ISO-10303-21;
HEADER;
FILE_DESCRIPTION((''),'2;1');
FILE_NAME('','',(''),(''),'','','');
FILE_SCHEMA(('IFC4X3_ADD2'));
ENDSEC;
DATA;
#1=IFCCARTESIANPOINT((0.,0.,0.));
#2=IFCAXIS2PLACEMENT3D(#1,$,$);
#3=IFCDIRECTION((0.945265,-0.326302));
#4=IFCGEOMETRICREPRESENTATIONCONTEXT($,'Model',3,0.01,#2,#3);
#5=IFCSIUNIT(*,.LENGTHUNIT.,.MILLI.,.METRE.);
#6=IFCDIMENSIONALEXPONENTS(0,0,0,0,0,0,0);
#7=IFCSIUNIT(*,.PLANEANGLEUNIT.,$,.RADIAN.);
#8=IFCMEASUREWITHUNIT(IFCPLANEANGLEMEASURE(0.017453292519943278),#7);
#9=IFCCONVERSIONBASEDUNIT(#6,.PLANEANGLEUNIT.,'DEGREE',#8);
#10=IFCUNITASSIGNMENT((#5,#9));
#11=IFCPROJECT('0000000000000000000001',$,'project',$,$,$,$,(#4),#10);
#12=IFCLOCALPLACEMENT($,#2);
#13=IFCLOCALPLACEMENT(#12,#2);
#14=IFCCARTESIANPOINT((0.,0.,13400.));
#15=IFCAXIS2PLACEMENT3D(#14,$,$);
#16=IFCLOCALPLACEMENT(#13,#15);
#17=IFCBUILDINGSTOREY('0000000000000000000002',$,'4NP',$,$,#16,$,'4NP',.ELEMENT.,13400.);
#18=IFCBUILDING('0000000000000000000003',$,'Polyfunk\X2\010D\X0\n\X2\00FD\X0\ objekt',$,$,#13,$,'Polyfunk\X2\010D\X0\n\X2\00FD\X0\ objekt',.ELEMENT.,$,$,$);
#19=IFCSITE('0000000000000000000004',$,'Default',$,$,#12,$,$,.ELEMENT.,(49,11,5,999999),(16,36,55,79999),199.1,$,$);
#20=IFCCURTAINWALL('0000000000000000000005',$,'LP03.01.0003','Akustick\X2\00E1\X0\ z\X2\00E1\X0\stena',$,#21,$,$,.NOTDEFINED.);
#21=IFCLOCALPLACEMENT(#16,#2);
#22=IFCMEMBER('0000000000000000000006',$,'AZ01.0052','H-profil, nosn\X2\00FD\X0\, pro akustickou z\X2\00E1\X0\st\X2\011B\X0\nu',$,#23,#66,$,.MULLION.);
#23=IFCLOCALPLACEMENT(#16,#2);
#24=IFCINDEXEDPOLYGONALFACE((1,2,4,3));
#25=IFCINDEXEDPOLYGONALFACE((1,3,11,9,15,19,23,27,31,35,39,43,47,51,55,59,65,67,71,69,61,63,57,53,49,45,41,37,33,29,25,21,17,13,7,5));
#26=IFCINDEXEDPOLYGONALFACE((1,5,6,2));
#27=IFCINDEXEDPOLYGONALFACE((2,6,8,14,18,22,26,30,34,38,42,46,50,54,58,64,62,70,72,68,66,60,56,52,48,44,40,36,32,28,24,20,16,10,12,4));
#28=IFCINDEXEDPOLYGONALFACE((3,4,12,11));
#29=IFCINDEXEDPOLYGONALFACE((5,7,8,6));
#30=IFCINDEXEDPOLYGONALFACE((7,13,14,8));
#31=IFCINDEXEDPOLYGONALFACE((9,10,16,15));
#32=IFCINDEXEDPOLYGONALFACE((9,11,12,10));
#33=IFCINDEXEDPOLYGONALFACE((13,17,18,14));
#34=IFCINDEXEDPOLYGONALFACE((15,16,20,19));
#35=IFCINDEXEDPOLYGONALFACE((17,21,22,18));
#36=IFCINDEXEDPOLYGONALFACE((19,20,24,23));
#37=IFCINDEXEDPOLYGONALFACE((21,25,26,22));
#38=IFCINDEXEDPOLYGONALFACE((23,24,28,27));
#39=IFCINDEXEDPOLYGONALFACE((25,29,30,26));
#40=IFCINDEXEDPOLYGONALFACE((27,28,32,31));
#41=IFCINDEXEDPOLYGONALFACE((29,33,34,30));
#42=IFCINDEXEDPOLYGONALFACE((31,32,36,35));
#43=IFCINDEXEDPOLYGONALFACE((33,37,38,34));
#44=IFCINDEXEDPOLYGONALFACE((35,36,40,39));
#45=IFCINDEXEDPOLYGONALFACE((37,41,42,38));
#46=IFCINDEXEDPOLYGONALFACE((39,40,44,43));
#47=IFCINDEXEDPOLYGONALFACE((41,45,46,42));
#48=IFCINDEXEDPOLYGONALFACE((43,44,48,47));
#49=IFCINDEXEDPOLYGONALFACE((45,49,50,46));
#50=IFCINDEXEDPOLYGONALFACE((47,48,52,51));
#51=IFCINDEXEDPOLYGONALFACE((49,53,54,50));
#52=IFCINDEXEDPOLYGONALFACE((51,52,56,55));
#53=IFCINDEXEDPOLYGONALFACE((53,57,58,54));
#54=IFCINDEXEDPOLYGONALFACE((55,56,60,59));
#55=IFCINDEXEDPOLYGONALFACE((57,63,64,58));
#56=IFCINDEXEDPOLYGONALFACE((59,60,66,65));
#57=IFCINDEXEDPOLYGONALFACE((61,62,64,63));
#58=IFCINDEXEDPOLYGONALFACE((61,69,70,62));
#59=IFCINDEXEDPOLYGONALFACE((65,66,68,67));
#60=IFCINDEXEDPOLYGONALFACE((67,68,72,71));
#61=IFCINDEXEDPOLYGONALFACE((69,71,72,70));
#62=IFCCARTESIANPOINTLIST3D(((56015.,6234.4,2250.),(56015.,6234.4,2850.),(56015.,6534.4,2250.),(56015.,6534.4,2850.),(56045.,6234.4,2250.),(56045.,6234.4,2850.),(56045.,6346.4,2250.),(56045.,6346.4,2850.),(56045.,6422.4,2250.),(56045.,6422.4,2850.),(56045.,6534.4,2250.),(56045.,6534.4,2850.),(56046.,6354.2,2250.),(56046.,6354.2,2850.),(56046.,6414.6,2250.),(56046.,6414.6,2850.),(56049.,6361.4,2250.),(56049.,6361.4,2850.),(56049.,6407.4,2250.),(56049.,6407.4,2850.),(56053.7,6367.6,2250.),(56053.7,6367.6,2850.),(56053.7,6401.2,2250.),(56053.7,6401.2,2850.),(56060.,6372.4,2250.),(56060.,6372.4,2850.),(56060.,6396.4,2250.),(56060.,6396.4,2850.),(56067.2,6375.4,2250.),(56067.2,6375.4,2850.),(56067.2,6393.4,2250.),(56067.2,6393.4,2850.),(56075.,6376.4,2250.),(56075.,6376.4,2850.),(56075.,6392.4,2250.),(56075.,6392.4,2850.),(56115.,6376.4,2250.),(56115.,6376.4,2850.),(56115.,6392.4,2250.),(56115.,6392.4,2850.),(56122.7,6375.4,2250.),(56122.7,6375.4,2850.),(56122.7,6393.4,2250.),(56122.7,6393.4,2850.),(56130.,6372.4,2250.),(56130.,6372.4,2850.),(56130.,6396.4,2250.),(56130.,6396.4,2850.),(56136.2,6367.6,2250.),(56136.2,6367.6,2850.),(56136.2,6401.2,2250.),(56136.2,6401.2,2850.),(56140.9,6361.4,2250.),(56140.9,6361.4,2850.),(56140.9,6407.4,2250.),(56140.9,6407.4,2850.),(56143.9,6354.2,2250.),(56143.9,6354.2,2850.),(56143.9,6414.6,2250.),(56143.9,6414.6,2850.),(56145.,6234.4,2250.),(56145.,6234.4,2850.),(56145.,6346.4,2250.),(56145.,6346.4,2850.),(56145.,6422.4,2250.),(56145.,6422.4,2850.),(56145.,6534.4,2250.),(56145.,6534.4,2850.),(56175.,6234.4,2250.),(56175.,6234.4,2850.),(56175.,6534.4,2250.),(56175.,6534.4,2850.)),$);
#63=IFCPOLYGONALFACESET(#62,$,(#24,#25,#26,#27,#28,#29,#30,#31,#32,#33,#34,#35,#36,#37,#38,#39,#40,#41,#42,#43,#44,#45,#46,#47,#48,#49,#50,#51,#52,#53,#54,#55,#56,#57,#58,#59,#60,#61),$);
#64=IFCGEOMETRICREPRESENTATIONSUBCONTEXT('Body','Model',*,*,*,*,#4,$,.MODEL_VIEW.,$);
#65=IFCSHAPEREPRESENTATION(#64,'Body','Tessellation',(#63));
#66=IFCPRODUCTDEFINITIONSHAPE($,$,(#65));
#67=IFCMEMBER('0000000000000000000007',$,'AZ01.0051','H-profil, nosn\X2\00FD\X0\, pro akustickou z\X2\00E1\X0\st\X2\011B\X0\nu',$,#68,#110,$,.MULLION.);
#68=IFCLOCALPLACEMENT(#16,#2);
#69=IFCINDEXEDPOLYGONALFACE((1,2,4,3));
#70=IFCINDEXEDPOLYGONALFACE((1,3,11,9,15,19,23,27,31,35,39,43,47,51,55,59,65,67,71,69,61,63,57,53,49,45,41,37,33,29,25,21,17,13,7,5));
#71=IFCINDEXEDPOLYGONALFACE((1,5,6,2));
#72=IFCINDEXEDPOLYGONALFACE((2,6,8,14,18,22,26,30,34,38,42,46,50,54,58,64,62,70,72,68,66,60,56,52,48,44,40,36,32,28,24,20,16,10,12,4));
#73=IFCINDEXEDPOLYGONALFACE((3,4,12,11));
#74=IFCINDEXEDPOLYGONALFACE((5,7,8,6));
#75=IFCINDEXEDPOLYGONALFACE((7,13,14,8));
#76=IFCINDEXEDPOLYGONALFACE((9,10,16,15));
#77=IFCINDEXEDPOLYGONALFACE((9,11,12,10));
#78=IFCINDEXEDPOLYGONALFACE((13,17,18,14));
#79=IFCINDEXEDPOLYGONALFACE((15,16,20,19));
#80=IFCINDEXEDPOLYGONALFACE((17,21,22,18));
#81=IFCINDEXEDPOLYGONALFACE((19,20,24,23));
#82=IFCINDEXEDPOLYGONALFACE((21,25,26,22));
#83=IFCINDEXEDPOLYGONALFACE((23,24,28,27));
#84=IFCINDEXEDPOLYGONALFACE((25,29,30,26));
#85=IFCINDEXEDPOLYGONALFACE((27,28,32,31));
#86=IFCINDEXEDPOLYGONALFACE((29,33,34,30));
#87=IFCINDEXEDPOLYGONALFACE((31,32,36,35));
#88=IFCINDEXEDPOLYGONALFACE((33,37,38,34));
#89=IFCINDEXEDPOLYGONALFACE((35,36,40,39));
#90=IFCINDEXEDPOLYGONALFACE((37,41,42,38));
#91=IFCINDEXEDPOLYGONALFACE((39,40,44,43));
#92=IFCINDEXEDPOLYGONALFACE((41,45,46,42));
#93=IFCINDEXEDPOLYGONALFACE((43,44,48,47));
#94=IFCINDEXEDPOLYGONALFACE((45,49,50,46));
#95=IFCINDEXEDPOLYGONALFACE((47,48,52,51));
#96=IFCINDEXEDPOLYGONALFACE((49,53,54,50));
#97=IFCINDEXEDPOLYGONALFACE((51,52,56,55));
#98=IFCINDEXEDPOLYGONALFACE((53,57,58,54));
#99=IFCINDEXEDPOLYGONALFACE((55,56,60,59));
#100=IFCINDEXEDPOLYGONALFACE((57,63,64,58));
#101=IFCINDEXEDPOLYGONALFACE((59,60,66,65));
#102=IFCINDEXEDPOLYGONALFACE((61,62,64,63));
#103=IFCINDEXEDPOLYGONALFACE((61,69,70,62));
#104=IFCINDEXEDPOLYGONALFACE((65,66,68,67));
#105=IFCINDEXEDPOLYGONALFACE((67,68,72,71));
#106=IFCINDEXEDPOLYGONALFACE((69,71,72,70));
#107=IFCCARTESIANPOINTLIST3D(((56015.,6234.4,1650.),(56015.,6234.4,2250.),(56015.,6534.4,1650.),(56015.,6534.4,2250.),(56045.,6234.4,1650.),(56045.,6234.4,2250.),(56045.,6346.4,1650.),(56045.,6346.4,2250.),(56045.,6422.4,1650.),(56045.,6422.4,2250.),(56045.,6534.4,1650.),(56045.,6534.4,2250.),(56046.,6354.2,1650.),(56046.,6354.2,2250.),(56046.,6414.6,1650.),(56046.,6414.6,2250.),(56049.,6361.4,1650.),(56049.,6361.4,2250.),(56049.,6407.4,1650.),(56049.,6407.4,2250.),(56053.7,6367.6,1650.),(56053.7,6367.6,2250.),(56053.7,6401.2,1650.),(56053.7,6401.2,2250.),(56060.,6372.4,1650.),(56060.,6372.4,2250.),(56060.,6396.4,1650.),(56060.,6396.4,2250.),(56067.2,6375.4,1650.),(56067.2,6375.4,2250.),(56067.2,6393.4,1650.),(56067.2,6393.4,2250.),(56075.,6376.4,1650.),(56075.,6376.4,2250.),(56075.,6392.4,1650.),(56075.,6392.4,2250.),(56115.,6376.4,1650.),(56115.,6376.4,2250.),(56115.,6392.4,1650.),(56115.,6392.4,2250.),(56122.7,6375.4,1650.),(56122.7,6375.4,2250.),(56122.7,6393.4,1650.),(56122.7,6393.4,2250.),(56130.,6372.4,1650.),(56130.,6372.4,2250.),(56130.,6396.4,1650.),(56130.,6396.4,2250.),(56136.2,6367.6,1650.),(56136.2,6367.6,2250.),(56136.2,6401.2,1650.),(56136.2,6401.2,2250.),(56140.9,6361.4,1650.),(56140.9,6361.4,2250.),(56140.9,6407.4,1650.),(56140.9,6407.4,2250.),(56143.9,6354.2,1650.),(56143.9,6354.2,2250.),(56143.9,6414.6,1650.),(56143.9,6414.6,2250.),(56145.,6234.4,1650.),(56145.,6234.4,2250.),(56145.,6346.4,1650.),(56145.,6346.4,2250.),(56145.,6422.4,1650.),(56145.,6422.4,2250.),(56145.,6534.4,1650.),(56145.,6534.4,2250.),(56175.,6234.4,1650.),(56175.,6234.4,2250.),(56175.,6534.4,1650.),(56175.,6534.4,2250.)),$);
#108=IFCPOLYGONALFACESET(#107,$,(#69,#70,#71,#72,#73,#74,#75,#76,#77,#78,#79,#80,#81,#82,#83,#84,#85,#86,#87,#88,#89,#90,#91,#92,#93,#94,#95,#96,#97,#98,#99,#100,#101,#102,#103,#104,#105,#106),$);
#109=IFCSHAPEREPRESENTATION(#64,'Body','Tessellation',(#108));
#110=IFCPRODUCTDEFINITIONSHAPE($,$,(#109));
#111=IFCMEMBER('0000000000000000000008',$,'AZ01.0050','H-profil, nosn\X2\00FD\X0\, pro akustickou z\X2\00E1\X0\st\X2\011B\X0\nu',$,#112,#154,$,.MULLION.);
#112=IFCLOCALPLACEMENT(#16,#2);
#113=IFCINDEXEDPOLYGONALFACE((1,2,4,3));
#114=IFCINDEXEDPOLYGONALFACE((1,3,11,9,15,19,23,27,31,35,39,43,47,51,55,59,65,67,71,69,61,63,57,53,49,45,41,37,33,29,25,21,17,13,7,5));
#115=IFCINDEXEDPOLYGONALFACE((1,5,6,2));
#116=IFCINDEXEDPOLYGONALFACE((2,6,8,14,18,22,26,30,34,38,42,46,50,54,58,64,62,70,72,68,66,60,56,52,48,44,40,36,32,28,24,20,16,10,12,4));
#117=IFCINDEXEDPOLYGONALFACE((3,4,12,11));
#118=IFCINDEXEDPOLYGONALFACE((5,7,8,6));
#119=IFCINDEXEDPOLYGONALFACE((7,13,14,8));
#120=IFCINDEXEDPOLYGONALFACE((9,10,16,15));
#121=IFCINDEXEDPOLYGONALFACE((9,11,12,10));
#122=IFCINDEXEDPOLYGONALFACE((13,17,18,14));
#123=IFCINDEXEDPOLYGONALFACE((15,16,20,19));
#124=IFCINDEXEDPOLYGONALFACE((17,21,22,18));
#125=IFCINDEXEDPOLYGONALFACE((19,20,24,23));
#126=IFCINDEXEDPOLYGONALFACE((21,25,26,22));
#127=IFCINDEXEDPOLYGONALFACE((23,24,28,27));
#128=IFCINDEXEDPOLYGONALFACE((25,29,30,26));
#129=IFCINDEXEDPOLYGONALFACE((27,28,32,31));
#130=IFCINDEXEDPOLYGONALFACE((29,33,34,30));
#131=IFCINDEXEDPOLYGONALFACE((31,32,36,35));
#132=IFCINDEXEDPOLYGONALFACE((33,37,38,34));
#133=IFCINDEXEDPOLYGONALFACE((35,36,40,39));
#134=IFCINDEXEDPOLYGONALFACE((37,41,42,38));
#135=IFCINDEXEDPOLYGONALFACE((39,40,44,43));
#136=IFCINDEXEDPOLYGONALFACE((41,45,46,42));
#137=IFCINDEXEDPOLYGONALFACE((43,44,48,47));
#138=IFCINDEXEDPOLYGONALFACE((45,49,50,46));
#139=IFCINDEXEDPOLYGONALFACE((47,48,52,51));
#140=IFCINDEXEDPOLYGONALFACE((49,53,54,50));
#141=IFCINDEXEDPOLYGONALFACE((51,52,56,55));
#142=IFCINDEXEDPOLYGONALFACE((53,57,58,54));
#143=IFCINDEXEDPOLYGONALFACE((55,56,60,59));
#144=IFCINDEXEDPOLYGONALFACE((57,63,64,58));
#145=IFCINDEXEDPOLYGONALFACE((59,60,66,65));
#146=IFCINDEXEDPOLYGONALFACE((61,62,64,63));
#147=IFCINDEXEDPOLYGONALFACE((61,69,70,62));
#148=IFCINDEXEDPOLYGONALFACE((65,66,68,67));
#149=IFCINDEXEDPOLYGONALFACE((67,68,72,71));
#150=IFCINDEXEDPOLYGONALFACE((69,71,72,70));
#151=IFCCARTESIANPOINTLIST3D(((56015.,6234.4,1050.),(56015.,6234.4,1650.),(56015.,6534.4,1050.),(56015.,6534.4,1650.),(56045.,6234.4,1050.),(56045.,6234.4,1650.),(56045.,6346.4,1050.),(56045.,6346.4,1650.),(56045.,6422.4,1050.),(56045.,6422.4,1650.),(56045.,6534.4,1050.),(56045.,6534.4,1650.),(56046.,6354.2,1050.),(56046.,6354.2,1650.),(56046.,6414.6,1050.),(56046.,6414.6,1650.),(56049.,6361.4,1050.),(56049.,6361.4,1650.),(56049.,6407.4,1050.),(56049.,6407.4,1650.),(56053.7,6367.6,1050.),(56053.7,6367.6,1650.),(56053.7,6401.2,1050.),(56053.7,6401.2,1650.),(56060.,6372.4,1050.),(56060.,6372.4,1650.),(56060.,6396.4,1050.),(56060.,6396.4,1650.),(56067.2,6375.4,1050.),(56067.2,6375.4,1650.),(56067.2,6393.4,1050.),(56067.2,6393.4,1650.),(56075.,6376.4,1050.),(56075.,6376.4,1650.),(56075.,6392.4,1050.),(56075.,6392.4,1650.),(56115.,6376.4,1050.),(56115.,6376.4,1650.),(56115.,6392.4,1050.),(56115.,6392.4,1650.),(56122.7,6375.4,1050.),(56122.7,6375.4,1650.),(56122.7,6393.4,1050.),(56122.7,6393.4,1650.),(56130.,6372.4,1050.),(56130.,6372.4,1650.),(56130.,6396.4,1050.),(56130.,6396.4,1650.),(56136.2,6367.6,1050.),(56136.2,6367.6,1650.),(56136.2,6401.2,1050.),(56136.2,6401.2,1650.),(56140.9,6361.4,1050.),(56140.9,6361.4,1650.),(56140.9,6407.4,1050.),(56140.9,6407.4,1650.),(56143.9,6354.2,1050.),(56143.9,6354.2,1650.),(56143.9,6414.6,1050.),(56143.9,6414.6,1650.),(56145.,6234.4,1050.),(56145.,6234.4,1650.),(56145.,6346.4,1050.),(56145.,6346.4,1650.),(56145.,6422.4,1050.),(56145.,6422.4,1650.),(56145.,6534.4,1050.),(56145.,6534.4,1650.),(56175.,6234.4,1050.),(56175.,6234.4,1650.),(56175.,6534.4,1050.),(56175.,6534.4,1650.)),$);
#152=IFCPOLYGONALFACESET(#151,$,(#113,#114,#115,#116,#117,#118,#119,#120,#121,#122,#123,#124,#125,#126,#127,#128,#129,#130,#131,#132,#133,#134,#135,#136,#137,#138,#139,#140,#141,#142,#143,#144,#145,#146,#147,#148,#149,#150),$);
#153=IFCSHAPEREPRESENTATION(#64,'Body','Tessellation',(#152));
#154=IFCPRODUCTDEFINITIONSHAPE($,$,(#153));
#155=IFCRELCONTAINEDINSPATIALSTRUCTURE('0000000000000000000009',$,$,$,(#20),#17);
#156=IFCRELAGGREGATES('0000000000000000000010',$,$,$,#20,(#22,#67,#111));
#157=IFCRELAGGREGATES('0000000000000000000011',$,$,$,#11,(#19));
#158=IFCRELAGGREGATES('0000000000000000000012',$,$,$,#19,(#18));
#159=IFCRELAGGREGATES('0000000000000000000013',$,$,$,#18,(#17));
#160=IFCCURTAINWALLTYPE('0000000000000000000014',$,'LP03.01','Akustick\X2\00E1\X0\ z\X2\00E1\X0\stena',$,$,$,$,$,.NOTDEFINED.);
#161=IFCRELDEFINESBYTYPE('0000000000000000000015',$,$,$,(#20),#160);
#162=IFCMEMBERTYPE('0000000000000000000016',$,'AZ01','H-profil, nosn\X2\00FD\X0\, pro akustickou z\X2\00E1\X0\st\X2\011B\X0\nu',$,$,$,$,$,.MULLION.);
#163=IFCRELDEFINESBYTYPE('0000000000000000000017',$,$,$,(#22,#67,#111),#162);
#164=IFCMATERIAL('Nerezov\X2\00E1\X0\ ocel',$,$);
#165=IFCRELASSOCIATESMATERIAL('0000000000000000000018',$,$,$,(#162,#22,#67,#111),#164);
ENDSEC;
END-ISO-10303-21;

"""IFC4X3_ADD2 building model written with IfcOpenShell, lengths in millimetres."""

from ifc_helpers import new_model, entity, si_unit, converted_unit, direction, frame, frame_2d, origin, place, context, subcontext, project, spatial, polyline, circle_curve, parameter, trimmed, segment, composite_curve, outline, extrude, source, transform, mapped, material, material_profile, profile_set, profile_usage, type_object, element, aggregate, save


model = new_model("IFC4X3_ADD2")

# Units and contexts
model_context = context("Model", 3, precision=0.01, world=origin(), true_north=direction((0.945265, -0.326302)))
body_context = subcontext(model_context, "Body", "Model", "MODEL_VIEW")
ifc_project = project(units=[si_unit("LENGTHUNIT", "METRE", prefix="MILLI"), converted_unit("PLANEANGLEUNIT", "DEGREE", entity("IfcPlaneAngleMeasure", 0.017453292519943278), si_unit("PLANEANGLEUNIT", "RADIAN"), dimensions=[0, 0, 0, 0, 0, 0, 0])], contexts=[model_context])

# Site, building, storey
site_placement = place(None, origin())
site = spatial("IfcSite", under=ifc_project, at=site_placement, Name="Default", CompositionType="ELEMENT", RefLatitude=(49, 11, 5, 999999), RefLongitude=(16, 36, 55, 79999), RefElevation=199.1)
building_placement = place(site_placement, origin())
building = spatial("IfcBuilding", under=site, at=building_placement, Name="Polyfunkčný objekt", LongName="Polyfunkčný objekt", CompositionType="ELEMENT")
storey_placement = place(building_placement, frame((0.0, 0.0, 13400.0)))
storey = spatial("IfcBuildingStorey", under=building, at=storey_placement, Name="4NP", LongName="4NP", CompositionType="ELEMENT", Elevation=13400.0)

# Shared definitions
curtain_wall_type = type_object("IfcCurtainWallType", Name="LP03.01", Description="Akustická zástena", PredefinedType="NOTDEFINED")
ifc_material_1 = material(Name="Nerezová ocel")
ifc_material_profile = material_profile(ifc_material_1, outline(composite_curve([segment(polyline([(50.0, -150.0), (80.0, -150.0)]), True, "CONTINUOUS"), segment(polyline([(80.0, -150.0), (80.0, 150.0)]), True, "CONTINUOUS"), segment(polyline([(80.0, 150.0), (50.0, 150.0)]), True, "CONTINUOUS"), segment(polyline([(50.0, 150.0), (50.0, 38.0)]), True, "CONTINUOUS"), segment(trimmed(circle_curve(frame_2d((20.0, 38.0), x_axis=(0.0, 1.0)), 30.0), [parameter(180.0)], [parameter(270.0)], True, "PARAMETER"), False, "CONTINUOUS"), segment(polyline([(20.0, 8.0), (-20.0, 8.0)]), True, "CONTINUOUS"), segment(trimmed(circle_curve(frame_2d((-20.0, 38.0), x_axis=(0.0, 1.0)), 30.0), [parameter(90.0)], [parameter(180.0)], True, "PARAMETER"), False, "CONTINUOUS"), segment(polyline([(-50.0, 38.0), (-50.0, 150.0)]), True, "CONTINUOUS"), segment(polyline([(-50.0, 150.0), (-80.0, 150.0)]), True, "CONTINUOUS"), segment(polyline([(-80.0, 150.0), (-80.0, -150.0)]), True, "CONTINUOUS"), segment(polyline([(-80.0, -150.0), (-50.0, -150.0)]), True, "CONTINUOUS"), segment(polyline([(-50.0, -150.0), (-50.0, -38.0)]), True, "CONTINUOUS"), segment(trimmed(circle_curve(frame_2d((-20.0, -38.0), x_axis=(0.0, 1.0)), 30.0), [parameter(0.0)], [parameter(90.0)], True, "PARAMETER"), False, "CONTINUOUS"), segment(polyline([(-20.0, -8.0), (20.0, -8.0)]), True, "CONTINUOUS"), segment(trimmed(circle_curve(frame_2d((20.0, -38.0), x_axis=(0.0, 1.0)), 30.0), [parameter(270.0)], [parameter(0.0)], True, "PARAMETER"), False, "CONTINUOUS"), segment(polyline([(50.0, -38.0), (50.0, -150.0)]), True, "CONTINUOUS")], self_intersect=False)), Name="Profil zástena")
ifc_profile_set = profile_set([ifc_material_profile], Name="Profil zástena")
ifc_profile_usage = profile_usage(ifc_profile_set)
member_type = type_object("IfcMemberType", Name="AZ01", Description="H-profil, nosný, pro akustickou zástěnu", PredefinedType="MULLION", material=ifc_profile_set)

# Curtain wall, members
curtain_wall_1_placement = place(storey_placement, frame((0.0, 0.0, -13400.0)))
curtain_wall_1 = element("IfcCurtainWall", 1, at=curtain_wall_1_placement, inside=storey, type_object=curtain_wall_type, Name="LP03.01.0003", Description="Akustická zástena", PredefinedType="NOTDEFINED")
shared_shape_1 = source(origin(), body_context, "Body", "SweptSolid", [
    extrude(outline(composite_curve([segment(polyline([(-150.0, -50.0), (-150.0, -80.0)]), True, "CONTINUOUS"), segment(polyline([(-150.0, -80.0), (150.0, -80.0)]), True, "CONTINUOUS"), segment(polyline([(150.0, -80.0), (150.0, -50.0)]), True, "CONTINUOUS"), segment(polyline([(150.0, -50.0), (38.0, -50.0)]), True, "CONTINUOUS"), segment(trimmed(circle_curve(frame_2d((38.0, -20.0), x_axis=(1.0, 0.0)), 30.0), [parameter(180.0)], [parameter(270.0)], True, "PARAMETER"), False, "CONTINUOUS"), segment(polyline([(8.0, -20.0), (8.0, 20.0)]), True, "CONTINUOUS"), segment(trimmed(circle_curve(frame_2d((38.0, 20.0), x_axis=(1.0, 0.0)), 30.0), [parameter(90.0)], [parameter(180.0)], True, "PARAMETER"), False, "CONTINUOUS"), segment(polyline([(38.0, 50.0), (150.0, 50.0)]), True, "CONTINUOUS"), segment(polyline([(150.0, 50.0), (150.0, 80.0)]), True, "CONTINUOUS"), segment(polyline([(150.0, 80.0), (-150.0, 80.0)]), True, "CONTINUOUS"), segment(polyline([(-150.0, 80.0), (-150.0, 50.0)]), True, "CONTINUOUS"), segment(polyline([(-150.0, 50.0), (-38.0, 50.0)]), True, "CONTINUOUS"), segment(trimmed(circle_curve(frame_2d((-38.0, 20.0), x_axis=(1.0, 0.0)), 30.0), [parameter(0.0)], [parameter(90.0)], True, "PARAMETER"), False, "CONTINUOUS"), segment(polyline([(-8.0, 20.0), (-8.0, -20.0)]), True, "CONTINUOUS"), segment(trimmed(circle_curve(frame_2d((-38.0, -20.0), x_axis=(1.0, 0.0)), 30.0), [parameter(270.0)], [parameter(0.0)], True, "PARAMETER"), False, "CONTINUOUS"), segment(polyline([(-38.0, -50.0), (-150.0, -50.0)]), True, "CONTINUOUS")], self_intersect=False)), frame((-150.0, 0.0, -600.0), z_axis=(0.0, 0.0, -1.0), x_axis=(1.0, 0.0, 0.0)), (0.0, 0.0, -1.0), 600.0),
])
member_1_placement = place(curtain_wall_1_placement, frame((56095.0, 6534.4, 15650.0), z_axis=(0.0, 0.0, -1.0), x_axis=(0.0, 1.0, 0.0)))
member_1 = element("IfcMember", 2, at=member_1_placement, type_object=member_type, material=ifc_profile_usage, Name="AZ01.0052", Description="H-profil, nosný, pro akustickou zástěnu", PredefinedType="MULLION", context=body_context, shape_type="MappedRepresentation", body=[
    mapped(shared_shape_1, transform((0.0, 0.0, 0.0), scale=1.0)),
])
member_2_placement = place(curtain_wall_1_placement, frame((56095.0, 6534.4, 15050.0), z_axis=(0.0, 0.0, -1.0), x_axis=(0.0, 1.0, 0.0)))
member_2 = element("IfcMember", 3, at=member_2_placement, type_object=member_type, material=ifc_profile_usage, Name="AZ01.0051", Description="H-profil, nosný, pro akustickou zástěnu", PredefinedType="MULLION", context=body_context, shape_type="MappedRepresentation", body=[
    mapped(shared_shape_1, transform((0.0, 0.0, 0.0), scale=1.0)),
])
member_3_placement = place(curtain_wall_1_placement, frame((56095.0, 6534.4, 14450.0), z_axis=(0.0, 0.0, -1.0), x_axis=(0.0, 1.0, 0.0)))
member_3 = element("IfcMember", 4, at=member_3_placement, type_object=member_type, material=ifc_profile_usage, Name="AZ01.0050", Description="H-profil, nosný, pro akustickou zástěnu", PredefinedType="MULLION", context=body_context, shape_type="MappedRepresentation", body=[
    mapped(shared_shape_1, transform((0.0, 0.0, 0.0), scale=1.0)),
])
aggregate(curtain_wall_1, [member_1, member_2, member_3])

save(model, "model.ifc")
